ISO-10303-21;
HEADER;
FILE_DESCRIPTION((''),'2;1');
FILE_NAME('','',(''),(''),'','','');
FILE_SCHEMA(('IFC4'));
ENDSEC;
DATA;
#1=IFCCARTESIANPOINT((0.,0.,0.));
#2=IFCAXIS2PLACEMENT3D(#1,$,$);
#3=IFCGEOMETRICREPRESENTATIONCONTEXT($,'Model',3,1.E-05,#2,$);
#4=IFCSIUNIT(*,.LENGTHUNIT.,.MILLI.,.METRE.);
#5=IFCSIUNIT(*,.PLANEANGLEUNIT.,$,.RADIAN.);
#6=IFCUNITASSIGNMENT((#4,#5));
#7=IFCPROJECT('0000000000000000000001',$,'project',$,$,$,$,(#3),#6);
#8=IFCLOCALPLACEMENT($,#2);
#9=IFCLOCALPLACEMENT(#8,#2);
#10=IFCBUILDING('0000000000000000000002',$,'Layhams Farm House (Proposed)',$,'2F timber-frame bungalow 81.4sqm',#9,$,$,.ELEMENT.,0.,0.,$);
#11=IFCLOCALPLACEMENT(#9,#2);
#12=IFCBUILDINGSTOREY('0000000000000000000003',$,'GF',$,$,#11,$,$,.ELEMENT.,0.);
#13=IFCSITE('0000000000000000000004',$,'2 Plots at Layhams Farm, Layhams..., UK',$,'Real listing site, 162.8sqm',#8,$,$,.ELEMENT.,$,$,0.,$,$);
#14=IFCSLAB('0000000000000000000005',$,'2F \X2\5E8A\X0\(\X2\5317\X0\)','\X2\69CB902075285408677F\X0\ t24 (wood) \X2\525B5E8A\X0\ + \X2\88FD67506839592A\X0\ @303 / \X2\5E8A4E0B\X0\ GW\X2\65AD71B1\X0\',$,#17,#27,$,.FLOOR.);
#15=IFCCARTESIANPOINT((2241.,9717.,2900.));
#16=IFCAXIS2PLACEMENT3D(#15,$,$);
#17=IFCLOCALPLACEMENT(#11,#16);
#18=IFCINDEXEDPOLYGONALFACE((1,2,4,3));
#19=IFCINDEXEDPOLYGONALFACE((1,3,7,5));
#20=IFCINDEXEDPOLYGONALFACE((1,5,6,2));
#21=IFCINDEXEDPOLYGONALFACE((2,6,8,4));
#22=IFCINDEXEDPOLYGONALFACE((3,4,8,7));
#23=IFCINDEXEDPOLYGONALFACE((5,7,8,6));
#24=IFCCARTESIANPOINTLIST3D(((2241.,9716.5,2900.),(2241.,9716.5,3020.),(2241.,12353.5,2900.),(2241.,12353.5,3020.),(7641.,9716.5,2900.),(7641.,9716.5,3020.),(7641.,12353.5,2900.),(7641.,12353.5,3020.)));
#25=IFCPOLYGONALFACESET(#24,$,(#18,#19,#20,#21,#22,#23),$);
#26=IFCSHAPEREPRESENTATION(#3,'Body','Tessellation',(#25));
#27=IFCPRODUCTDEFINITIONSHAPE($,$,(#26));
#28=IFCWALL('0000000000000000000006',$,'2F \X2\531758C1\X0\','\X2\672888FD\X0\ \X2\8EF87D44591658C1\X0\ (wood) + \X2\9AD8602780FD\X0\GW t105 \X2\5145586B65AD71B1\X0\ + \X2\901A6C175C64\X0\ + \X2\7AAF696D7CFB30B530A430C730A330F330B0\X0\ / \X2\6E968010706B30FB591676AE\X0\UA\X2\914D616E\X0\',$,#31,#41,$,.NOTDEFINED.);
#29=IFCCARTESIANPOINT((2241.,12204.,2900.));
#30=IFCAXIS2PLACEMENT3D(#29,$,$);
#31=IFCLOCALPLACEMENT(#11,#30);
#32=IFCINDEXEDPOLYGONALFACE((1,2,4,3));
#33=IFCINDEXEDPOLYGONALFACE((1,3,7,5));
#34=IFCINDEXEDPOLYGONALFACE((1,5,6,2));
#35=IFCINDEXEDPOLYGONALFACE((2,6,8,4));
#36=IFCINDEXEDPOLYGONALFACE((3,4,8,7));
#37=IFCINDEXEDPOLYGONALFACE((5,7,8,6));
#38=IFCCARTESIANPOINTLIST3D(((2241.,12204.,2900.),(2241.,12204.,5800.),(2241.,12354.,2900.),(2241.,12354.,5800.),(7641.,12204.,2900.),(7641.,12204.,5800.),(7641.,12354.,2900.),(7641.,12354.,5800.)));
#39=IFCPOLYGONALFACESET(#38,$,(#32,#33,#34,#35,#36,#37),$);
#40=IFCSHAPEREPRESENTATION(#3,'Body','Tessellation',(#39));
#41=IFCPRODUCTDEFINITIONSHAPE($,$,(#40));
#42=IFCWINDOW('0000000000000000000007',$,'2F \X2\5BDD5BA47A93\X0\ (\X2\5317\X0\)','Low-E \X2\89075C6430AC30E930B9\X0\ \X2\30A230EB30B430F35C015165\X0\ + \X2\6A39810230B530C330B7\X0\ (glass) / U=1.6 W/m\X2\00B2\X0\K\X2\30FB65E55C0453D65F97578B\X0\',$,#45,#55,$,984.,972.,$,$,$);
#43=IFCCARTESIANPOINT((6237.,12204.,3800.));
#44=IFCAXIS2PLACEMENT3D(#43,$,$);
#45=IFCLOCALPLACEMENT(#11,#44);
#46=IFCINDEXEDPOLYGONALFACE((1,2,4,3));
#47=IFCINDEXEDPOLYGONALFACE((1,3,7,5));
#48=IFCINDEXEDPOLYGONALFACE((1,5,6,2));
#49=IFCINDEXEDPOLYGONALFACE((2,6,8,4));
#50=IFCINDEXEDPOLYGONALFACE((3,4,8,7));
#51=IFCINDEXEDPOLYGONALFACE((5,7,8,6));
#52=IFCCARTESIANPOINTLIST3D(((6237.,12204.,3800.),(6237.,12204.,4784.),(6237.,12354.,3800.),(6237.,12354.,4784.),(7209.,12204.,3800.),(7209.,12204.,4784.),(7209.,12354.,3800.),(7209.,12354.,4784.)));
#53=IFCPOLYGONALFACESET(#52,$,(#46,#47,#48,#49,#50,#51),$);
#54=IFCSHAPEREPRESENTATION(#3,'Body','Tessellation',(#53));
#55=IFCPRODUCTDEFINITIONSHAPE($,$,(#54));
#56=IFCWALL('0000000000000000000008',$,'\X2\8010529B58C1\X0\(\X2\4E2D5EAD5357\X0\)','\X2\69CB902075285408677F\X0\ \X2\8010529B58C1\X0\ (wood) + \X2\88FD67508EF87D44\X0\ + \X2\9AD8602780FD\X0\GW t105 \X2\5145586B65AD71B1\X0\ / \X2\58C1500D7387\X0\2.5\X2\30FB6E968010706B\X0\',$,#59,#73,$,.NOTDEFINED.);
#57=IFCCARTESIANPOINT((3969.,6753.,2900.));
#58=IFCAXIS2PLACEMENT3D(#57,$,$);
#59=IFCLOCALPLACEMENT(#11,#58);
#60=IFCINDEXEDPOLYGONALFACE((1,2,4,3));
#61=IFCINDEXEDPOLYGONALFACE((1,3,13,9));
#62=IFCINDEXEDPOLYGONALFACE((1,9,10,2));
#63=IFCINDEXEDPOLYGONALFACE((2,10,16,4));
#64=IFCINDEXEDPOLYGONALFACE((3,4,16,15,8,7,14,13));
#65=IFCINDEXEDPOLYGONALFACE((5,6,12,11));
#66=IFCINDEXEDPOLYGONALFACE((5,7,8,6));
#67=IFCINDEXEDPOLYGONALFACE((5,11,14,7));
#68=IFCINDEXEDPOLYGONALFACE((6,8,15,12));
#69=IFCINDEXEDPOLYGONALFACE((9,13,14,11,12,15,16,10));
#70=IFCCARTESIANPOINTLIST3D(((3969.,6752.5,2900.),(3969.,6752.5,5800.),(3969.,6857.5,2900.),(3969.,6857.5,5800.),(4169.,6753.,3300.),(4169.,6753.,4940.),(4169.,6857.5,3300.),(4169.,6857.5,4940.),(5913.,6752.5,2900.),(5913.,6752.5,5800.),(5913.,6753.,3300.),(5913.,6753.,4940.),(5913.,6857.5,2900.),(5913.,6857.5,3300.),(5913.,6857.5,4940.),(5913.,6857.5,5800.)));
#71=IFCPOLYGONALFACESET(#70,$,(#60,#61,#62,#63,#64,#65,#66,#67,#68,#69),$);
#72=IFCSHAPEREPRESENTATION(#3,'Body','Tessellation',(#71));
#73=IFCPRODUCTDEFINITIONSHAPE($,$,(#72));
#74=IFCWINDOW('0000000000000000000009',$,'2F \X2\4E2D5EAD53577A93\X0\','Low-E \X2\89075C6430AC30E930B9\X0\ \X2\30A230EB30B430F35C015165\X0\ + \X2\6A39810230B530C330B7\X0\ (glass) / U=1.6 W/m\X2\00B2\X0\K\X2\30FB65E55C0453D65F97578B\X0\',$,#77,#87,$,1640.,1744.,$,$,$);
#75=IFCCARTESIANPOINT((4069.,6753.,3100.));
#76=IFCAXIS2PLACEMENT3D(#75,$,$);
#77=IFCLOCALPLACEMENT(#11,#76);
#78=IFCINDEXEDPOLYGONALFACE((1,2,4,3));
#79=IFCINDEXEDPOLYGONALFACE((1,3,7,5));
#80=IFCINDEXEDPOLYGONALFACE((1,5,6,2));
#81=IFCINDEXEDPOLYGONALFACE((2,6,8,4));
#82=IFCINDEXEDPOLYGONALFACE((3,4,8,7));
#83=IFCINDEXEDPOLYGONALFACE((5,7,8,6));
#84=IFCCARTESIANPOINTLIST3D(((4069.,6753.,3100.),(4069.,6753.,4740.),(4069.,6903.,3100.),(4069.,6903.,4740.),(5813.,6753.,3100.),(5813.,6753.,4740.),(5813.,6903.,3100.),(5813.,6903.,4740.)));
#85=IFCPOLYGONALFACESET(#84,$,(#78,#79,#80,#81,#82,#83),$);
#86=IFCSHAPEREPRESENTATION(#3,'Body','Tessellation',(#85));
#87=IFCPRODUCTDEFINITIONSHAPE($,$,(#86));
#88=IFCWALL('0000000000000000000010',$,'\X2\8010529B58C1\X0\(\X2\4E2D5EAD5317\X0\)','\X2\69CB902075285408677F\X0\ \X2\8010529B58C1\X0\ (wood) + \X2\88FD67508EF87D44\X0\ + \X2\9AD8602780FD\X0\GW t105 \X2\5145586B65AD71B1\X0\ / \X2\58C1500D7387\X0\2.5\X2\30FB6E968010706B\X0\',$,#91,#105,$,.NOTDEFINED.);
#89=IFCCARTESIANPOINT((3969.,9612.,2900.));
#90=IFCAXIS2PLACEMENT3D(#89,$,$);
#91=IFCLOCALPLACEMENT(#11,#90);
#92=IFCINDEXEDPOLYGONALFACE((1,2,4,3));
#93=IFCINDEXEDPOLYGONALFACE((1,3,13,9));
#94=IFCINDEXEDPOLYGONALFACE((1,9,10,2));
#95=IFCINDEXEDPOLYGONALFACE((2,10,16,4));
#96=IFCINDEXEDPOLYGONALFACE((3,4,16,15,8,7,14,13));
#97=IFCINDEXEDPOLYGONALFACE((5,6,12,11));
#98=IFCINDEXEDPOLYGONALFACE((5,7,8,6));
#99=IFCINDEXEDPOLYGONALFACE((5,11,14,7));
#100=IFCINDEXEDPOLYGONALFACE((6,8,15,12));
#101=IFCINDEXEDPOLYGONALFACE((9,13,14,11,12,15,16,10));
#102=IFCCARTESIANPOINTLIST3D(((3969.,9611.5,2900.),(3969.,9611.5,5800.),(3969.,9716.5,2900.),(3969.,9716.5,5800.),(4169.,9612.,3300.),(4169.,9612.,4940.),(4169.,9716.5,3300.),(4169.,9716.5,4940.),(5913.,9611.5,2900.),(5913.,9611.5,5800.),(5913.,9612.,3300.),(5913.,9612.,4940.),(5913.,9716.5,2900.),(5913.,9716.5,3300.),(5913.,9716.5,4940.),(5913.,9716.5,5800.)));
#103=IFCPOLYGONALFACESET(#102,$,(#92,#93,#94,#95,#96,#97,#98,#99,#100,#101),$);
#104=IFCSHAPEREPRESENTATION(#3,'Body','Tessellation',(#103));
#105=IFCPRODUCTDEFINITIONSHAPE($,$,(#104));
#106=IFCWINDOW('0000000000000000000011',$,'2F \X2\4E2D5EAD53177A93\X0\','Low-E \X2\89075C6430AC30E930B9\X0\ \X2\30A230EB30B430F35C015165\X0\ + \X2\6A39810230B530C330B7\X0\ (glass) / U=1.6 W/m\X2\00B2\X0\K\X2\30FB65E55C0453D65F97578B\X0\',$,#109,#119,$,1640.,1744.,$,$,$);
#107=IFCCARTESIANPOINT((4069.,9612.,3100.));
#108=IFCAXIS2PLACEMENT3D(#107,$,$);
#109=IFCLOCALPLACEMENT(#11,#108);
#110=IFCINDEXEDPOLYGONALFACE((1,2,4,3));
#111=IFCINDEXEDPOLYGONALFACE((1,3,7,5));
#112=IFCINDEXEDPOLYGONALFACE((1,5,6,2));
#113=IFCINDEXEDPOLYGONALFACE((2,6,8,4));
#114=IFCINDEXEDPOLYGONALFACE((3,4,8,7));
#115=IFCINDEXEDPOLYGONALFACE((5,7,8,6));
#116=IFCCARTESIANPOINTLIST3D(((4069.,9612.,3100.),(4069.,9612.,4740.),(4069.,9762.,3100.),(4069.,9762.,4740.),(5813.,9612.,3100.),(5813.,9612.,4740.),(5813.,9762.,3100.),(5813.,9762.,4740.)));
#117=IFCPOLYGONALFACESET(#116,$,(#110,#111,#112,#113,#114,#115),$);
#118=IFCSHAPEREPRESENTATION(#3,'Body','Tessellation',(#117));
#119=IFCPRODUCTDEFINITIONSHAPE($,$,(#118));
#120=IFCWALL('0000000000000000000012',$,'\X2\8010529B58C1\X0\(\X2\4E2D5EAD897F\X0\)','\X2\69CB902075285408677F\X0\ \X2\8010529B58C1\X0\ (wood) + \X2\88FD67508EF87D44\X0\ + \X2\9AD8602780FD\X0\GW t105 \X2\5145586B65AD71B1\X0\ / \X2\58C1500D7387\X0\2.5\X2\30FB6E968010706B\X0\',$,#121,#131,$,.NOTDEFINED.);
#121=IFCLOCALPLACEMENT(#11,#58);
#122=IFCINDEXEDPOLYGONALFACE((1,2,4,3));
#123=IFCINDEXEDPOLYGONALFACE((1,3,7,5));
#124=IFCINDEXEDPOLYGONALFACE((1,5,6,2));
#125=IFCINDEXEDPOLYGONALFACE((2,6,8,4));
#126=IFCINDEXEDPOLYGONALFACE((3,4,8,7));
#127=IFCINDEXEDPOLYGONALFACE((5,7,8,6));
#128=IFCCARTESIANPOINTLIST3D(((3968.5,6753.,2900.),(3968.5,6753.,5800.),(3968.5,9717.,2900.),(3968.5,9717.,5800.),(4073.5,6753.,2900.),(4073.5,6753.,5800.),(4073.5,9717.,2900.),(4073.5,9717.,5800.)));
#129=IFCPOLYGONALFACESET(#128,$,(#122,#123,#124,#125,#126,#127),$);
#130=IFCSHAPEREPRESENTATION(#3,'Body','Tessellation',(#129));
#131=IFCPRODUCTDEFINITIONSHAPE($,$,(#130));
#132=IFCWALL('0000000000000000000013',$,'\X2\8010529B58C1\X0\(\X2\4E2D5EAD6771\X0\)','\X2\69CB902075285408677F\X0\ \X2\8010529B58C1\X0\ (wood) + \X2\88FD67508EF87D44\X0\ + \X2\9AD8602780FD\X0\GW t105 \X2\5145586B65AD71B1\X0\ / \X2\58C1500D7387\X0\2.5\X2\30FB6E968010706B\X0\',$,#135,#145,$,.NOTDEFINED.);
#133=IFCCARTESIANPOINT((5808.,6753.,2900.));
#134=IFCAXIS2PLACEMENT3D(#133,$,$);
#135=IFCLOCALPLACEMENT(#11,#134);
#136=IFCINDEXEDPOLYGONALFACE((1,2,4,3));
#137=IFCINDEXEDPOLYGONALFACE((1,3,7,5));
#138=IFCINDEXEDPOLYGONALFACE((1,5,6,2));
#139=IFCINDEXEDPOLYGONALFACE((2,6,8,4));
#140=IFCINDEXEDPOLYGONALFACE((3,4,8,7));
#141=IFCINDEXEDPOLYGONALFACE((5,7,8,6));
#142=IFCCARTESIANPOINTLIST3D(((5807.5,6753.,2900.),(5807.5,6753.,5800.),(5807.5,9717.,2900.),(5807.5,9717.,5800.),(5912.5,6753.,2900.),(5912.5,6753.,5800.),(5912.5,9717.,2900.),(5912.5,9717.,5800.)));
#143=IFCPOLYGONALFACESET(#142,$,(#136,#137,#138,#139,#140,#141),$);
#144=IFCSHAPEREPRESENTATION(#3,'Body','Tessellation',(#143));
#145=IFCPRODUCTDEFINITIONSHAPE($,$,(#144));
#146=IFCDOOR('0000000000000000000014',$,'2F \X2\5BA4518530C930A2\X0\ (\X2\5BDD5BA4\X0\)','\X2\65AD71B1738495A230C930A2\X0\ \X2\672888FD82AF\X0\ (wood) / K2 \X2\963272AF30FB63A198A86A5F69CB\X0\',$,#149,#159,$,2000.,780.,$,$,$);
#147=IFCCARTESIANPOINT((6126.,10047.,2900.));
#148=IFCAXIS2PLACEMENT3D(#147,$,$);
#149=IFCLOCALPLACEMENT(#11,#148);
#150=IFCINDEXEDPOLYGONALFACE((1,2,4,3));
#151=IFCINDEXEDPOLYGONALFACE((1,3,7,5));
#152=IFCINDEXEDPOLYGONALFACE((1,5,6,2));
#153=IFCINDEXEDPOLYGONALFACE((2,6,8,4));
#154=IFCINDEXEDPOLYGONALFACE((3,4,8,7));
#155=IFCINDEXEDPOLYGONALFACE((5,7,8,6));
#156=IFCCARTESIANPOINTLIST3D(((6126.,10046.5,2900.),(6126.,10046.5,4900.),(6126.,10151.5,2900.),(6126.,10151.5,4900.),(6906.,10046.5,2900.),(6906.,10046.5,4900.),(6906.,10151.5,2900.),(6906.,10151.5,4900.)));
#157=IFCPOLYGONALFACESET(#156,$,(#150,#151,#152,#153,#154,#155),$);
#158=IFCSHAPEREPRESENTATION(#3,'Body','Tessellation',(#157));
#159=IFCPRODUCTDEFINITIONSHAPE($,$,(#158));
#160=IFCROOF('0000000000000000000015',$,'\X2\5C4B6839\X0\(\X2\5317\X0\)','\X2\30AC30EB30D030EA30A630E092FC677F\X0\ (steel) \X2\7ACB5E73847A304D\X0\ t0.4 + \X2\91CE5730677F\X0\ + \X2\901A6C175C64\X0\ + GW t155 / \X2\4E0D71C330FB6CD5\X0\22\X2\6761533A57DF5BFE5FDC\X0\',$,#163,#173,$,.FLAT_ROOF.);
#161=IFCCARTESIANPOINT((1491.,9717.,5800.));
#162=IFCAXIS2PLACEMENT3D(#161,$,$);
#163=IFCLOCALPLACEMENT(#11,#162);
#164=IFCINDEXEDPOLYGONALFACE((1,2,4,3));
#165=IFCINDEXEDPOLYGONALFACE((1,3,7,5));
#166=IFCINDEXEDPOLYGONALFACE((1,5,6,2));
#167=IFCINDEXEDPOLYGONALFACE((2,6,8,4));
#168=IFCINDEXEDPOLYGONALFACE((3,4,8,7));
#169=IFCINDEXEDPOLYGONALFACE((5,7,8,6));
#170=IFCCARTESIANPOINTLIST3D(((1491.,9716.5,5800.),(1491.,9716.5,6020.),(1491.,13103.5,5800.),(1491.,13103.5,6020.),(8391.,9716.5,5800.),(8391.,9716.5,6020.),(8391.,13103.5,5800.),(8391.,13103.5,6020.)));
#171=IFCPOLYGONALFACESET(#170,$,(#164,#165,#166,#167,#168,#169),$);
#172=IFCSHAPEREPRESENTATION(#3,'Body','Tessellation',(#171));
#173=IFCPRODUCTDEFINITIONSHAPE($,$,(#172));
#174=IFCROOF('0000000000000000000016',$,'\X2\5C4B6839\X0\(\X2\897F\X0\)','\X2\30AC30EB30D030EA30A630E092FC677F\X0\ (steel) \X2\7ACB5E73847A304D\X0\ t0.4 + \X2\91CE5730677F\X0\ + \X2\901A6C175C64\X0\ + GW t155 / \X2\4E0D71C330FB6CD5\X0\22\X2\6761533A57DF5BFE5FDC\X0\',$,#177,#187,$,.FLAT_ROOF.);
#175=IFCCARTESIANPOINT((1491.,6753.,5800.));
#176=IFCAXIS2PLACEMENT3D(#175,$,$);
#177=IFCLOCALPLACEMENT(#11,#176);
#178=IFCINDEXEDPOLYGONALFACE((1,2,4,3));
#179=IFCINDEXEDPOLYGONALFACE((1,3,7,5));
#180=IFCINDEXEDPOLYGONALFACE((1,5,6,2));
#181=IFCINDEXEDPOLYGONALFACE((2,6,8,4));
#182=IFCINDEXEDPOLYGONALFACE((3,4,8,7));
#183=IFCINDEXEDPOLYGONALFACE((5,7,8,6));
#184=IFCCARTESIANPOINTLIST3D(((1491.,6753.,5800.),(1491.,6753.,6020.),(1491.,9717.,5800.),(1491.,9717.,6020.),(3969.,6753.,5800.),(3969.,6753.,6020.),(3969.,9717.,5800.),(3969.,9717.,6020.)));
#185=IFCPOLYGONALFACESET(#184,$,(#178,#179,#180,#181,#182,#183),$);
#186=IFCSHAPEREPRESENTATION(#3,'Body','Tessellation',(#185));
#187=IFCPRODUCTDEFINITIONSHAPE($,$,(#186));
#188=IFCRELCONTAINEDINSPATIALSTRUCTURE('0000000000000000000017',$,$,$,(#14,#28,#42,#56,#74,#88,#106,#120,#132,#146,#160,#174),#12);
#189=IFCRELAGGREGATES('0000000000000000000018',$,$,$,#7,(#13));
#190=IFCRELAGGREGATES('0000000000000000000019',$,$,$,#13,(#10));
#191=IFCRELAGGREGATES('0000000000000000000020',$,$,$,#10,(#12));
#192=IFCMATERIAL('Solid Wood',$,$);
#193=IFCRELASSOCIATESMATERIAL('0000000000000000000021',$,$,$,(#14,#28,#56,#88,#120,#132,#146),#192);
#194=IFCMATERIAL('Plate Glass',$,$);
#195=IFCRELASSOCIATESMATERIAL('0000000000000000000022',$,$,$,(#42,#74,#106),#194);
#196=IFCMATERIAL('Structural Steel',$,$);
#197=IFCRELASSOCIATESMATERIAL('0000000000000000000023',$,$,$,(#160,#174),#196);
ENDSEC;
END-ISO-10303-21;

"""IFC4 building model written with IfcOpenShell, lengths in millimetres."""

from ifc_helpers import new_model, si_unit, frame, frame_2d, origin, place, context, project, spatial, rectangle, extrude, material, element, fill, save


model = new_model("IFC4")

# Units and contexts
model_context = context("Model", 3, precision=1e-05, world=origin())
ifc_project = project(units=[si_unit("LENGTHUNIT", "METRE", prefix="MILLI"), si_unit("PLANEANGLEUNIT", "RADIAN")], contexts=[model_context])

# Site, building, storey
site_placement = place(None, origin())
site = spatial("IfcSite", under=ifc_project, at=site_placement, Name="2 Plots at Layhams Farm, Layhams..., UK", ObjectType="Real listing site, 162.8sqm", CompositionType="ELEMENT", RefElevation=0.0)
building_placement = place(site_placement, origin())
building = spatial("IfcBuilding", under=site, at=building_placement, Name="Layhams Farm House (Proposed)", ObjectType="2F timber-frame bungalow 81.4sqm", CompositionType="ELEMENT", ElevationOfRefHeight=0.0, ElevationOfTerrain=0.0)
storey_placement = place(building_placement, origin())
storey = spatial("IfcBuildingStorey", under=building, at=storey_placement, Name="GF", CompositionType="ELEMENT", Elevation=0.0)

# Slab
ifc_material_1 = material(Name="Solid Wood")
slab_placement = place(storey_placement, frame((2241.0, 9717.0, 2900.0)))
element("IfcSlab", 1, at=slab_placement, inside=storey, material=ifc_material_1, Name="2F 床(北)", Description="構造用合板 t24 (wood) 剛床 + 製材根太 @303 / 床下 GW断熱", PredefinedType="FLOOR", context=model_context, shape_type="SweptSolid", body=[
    extrude(rectangle(XDim=5400.0, YDim=2637.0, at=frame_2d((2700.0, 1318.0))), frame((2241.0, 9717.0, 2900.0)), (0.0, 0.0, 1.0), 120.0),
])

# Walls, openings, windows
wall_1_placement = place(storey_placement, frame((2241.0, 12204.0, 2900.0)))
wall_1 = element("IfcWall", 2, at=wall_1_placement, inside=storey, material=ifc_material_1, Name="2F 北壁", Description="木製 軸組外壁 (wood) + 高性能GW t105 充填断熱 + 通気層 + 窯業系サイディング / 準耐火・外皮UA配慮", PredefinedType="NOTDEFINED", context=model_context, shape_type="SweptSolid", body=[
    extrude(rectangle(XDim=5400.0, YDim=150.0, at=frame_2d((2700.0, 75.0))), frame((2241.0, 12204.0, 2900.0)), (0.0, 0.0, 1.0), 2900.0),
])
opening_1_placement = place(storey_placement, frame((6237.0, 12204.0, 3800.0)))
opening_1 = element("IfcOpeningElement", 3, at=opening_1_placement, cuts=wall_1, PredefinedType="NOTDEFINED", context=model_context, shape_type="SweptSolid", body=[
    extrude(rectangle(XDim=972.0, YDim=150.0, at=frame_2d((486.0, 75.0))), frame((6237.0, 12204.0, 3800.0)), (0.0, 0.0, 1.0), 984.0),
])
ifc_material_2 = material(Name="Plate Glass")
window_1_placement = place(storey_placement, frame((6237.0, 12204.0, 3800.0)))
window_1 = element("IfcWindow", 4, at=window_1_placement, inside=storey, material=ifc_material_2, Name="2F 寝室窓 (北)", Description="Low-E 複層ガラス アルゴン封入 + 樹脂サッシ (glass) / U=1.6 W/m²K・日射取得型", OverallHeight=984.0, OverallWidth=972.0, context=model_context, shape_type="SweptSolid", body=[
    extrude(rectangle(XDim=972.0, YDim=150.0, at=frame_2d((486.0, 75.0))), frame((6237.0, 12204.0, 3800.0)), (0.0, 0.0, 1.0), 984.0),
])
fill(opening_1, window_1)
wall_2_placement = place(storey_placement, frame((3969.0, 6753.0, 2900.0)))
wall_2 = element("IfcWall", 5, at=wall_2_placement, inside=storey, material=ifc_material_1, Name="耐力壁(中庭南)", Description="構造用合板 耐力壁 (wood) + 製材軸組 + 高性能GW t105 充填断熱 / 壁倍率2.5・準耐火", PredefinedType="NOTDEFINED", context=model_context, shape_type="SweptSolid", body=[
    extrude(rectangle(XDim=1944.0, YDim=105.0, at=frame_2d((972.0, 52.0))), frame((3969.0, 6753.0, 2900.0)), (0.0, 0.0, 1.0), 2900.0),
])
opening_2_placement = place(storey_placement, frame((4069.0, 6753.0, 3100.0)))
opening_2 = element("IfcOpeningElement", 6, at=opening_2_placement, cuts=wall_2, PredefinedType="NOTDEFINED", context=model_context, shape_type="SweptSolid", body=[
    extrude(rectangle(XDim=1744.0, YDim=150.0, at=frame_2d((872.0, 75.0))), frame((4069.0, 6753.0, 3100.0)), (0.0, 0.0, 1.0), 1640.0),
])
window_2_placement = place(storey_placement, frame((4069.0, 6753.0, 3100.0)))
window_2 = element("IfcWindow", 7, at=window_2_placement, inside=storey, material=ifc_material_2, Name="2F 中庭南窓", Description="Low-E 複層ガラス アルゴン封入 + 樹脂サッシ (glass) / U=1.6 W/m²K・日射取得型", OverallHeight=1640.0, OverallWidth=1744.0, context=model_context, shape_type="SweptSolid", body=[
    extrude(rectangle(XDim=1744.0, YDim=150.0, at=frame_2d((872.0, 75.0))), frame((4069.0, 6753.0, 3100.0)), (0.0, 0.0, 1.0), 1640.0),
])
fill(opening_2, window_2)
wall_3_placement = place(storey_placement, frame((3969.0, 9612.0, 2900.0)))
wall_3 = element("IfcWall", 8, at=wall_3_placement, inside=storey, material=ifc_material_1, Name="耐力壁(中庭北)", Description="構造用合板 耐力壁 (wood) + 製材軸組 + 高性能GW t105 充填断熱 / 壁倍率2.5・準耐火", PredefinedType="NOTDEFINED", context=model_context, shape_type="SweptSolid", body=[
    extrude(rectangle(XDim=1944.0, YDim=105.0, at=frame_2d((972.0, 52.0))), frame((3969.0, 9612.0, 2900.0)), (0.0, 0.0, 1.0), 2900.0),
])
opening_3_placement = place(storey_placement, frame((4069.0, 9612.0, 3100.0)))
opening_3 = element("IfcOpeningElement", 9, at=opening_3_placement, cuts=wall_3, PredefinedType="NOTDEFINED", context=model_context, shape_type="SweptSolid", body=[
    extrude(rectangle(XDim=1744.0, YDim=150.0, at=frame_2d((872.0, 75.0))), frame((4069.0, 9612.0, 3100.0)), (0.0, 0.0, 1.0), 1640.0),
])
window_3_placement = place(storey_placement, frame((4069.0, 9612.0, 3100.0)))
window_3 = element("IfcWindow", 10, at=window_3_placement, inside=storey, material=ifc_material_2, Name="2F 中庭北窓", Description="Low-E 複層ガラス アルゴン封入 + 樹脂サッシ (glass) / U=1.6 W/m²K・日射取得型", OverallHeight=1640.0, OverallWidth=1744.0, context=model_context, shape_type="SweptSolid", body=[
    extrude(rectangle(XDim=1744.0, YDim=150.0, at=frame_2d((872.0, 75.0))), frame((4069.0, 9612.0, 3100.0)), (0.0, 0.0, 1.0), 1640.0),
])
fill(opening_3, window_3)

# Walls
wall_4_placement = place(storey_placement, frame((3969.0, 6753.0, 2900.0)))
element("IfcWall", 11, at=wall_4_placement, inside=storey, material=ifc_material_1, Name="耐力壁(中庭西)", Description="構造用合板 耐力壁 (wood) + 製材軸組 + 高性能GW t105 充填断熱 / 壁倍率2.5・準耐火", PredefinedType="NOTDEFINED", context=model_context, shape_type="SweptSolid", body=[
    extrude(rectangle(XDim=105.0, YDim=2964.0, at=frame_2d((52.0, 1482.0))), frame((3969.0, 6753.0, 2900.0)), (0.0, 0.0, 1.0), 2900.0),
])
wall_5_placement = place(storey_placement, frame((5808.0, 6753.0, 2900.0)))
element("IfcWall", 12, at=wall_5_placement, inside=storey, material=ifc_material_1, Name="耐力壁(中庭東)", Description="構造用合板 耐力壁 (wood) + 製材軸組 + 高性能GW t105 充填断熱 / 壁倍率2.5・準耐火", PredefinedType="NOTDEFINED", context=model_context, shape_type="SweptSolid", body=[
    extrude(rectangle(XDim=105.0, YDim=2964.0, at=frame_2d((52.0, 1482.0))), frame((5808.0, 6753.0, 2900.0)), (0.0, 0.0, 1.0), 2900.0),
])

# Door
door_placement = place(storey_placement, frame((6126.0, 10047.0, 2900.0)))
element("IfcDoor", 13, at=door_placement, inside=storey, material=ifc_material_1, Name="2F 室内ドア (寝室)", Description="断熱玄関ドア 木製芯 (wood) / K2 防犯・採風機構", OverallHeight=2000.0, OverallWidth=780.0, context=model_context, shape_type="SweptSolid", body=[
    extrude(rectangle(XDim=780.0, YDim=105.0, at=frame_2d((390.0, 52.0))), frame((6126.0, 10047.0, 2900.0)), (0.0, 0.0, 1.0), 2000.0),
])

# Roofs
ifc_material_3 = material(Name="Structural Steel")
for number, where, name in (
    (14, (1491.0, 9717.0, 5800.0), "屋根(北)"),
):
    element("IfcRoof", number, at=place(storey_placement, frame(where)), inside=storey, material=ifc_material_3, Name=name, Description="ガルバリウム鋼板 (steel) 立平葺き t0.4 + 野地板 + 通気層 + GW t155 / 不燃・法22条区域対応", PredefinedType="FLAT_ROOF", context=model_context, shape_type="SweptSolid", body=[
        extrude(rectangle(XDim=6900.0, YDim=3387.0, at=frame_2d((3450.0, 1693.0))), frame((1491.0, 9717.0, 5800.0)), (0.0, 0.0, 1.0), 220.0),
    ])
roof_1_placement = place(storey_placement, frame((1491.0, 6753.0, 5800.0)))
element("IfcRoof", 15, at=roof_1_placement, inside=storey, material=ifc_material_3, Name="屋根(西)", Description="ガルバリウム鋼板 (steel) 立平葺き t0.4 + 野地板 + 通気層 + GW t155 / 不燃・法22条区域対応", PredefinedType="FLAT_ROOF", context=model_context, shape_type="SweptSolid", body=[
    extrude(rectangle(XDim=2478.0, YDim=2964.0, at=frame_2d((1239.0, 1482.0))), frame((1491.0, 6753.0, 5800.0)), (0.0, 0.0, 1.0), 220.0),
])

save(model, "model.ifc")
